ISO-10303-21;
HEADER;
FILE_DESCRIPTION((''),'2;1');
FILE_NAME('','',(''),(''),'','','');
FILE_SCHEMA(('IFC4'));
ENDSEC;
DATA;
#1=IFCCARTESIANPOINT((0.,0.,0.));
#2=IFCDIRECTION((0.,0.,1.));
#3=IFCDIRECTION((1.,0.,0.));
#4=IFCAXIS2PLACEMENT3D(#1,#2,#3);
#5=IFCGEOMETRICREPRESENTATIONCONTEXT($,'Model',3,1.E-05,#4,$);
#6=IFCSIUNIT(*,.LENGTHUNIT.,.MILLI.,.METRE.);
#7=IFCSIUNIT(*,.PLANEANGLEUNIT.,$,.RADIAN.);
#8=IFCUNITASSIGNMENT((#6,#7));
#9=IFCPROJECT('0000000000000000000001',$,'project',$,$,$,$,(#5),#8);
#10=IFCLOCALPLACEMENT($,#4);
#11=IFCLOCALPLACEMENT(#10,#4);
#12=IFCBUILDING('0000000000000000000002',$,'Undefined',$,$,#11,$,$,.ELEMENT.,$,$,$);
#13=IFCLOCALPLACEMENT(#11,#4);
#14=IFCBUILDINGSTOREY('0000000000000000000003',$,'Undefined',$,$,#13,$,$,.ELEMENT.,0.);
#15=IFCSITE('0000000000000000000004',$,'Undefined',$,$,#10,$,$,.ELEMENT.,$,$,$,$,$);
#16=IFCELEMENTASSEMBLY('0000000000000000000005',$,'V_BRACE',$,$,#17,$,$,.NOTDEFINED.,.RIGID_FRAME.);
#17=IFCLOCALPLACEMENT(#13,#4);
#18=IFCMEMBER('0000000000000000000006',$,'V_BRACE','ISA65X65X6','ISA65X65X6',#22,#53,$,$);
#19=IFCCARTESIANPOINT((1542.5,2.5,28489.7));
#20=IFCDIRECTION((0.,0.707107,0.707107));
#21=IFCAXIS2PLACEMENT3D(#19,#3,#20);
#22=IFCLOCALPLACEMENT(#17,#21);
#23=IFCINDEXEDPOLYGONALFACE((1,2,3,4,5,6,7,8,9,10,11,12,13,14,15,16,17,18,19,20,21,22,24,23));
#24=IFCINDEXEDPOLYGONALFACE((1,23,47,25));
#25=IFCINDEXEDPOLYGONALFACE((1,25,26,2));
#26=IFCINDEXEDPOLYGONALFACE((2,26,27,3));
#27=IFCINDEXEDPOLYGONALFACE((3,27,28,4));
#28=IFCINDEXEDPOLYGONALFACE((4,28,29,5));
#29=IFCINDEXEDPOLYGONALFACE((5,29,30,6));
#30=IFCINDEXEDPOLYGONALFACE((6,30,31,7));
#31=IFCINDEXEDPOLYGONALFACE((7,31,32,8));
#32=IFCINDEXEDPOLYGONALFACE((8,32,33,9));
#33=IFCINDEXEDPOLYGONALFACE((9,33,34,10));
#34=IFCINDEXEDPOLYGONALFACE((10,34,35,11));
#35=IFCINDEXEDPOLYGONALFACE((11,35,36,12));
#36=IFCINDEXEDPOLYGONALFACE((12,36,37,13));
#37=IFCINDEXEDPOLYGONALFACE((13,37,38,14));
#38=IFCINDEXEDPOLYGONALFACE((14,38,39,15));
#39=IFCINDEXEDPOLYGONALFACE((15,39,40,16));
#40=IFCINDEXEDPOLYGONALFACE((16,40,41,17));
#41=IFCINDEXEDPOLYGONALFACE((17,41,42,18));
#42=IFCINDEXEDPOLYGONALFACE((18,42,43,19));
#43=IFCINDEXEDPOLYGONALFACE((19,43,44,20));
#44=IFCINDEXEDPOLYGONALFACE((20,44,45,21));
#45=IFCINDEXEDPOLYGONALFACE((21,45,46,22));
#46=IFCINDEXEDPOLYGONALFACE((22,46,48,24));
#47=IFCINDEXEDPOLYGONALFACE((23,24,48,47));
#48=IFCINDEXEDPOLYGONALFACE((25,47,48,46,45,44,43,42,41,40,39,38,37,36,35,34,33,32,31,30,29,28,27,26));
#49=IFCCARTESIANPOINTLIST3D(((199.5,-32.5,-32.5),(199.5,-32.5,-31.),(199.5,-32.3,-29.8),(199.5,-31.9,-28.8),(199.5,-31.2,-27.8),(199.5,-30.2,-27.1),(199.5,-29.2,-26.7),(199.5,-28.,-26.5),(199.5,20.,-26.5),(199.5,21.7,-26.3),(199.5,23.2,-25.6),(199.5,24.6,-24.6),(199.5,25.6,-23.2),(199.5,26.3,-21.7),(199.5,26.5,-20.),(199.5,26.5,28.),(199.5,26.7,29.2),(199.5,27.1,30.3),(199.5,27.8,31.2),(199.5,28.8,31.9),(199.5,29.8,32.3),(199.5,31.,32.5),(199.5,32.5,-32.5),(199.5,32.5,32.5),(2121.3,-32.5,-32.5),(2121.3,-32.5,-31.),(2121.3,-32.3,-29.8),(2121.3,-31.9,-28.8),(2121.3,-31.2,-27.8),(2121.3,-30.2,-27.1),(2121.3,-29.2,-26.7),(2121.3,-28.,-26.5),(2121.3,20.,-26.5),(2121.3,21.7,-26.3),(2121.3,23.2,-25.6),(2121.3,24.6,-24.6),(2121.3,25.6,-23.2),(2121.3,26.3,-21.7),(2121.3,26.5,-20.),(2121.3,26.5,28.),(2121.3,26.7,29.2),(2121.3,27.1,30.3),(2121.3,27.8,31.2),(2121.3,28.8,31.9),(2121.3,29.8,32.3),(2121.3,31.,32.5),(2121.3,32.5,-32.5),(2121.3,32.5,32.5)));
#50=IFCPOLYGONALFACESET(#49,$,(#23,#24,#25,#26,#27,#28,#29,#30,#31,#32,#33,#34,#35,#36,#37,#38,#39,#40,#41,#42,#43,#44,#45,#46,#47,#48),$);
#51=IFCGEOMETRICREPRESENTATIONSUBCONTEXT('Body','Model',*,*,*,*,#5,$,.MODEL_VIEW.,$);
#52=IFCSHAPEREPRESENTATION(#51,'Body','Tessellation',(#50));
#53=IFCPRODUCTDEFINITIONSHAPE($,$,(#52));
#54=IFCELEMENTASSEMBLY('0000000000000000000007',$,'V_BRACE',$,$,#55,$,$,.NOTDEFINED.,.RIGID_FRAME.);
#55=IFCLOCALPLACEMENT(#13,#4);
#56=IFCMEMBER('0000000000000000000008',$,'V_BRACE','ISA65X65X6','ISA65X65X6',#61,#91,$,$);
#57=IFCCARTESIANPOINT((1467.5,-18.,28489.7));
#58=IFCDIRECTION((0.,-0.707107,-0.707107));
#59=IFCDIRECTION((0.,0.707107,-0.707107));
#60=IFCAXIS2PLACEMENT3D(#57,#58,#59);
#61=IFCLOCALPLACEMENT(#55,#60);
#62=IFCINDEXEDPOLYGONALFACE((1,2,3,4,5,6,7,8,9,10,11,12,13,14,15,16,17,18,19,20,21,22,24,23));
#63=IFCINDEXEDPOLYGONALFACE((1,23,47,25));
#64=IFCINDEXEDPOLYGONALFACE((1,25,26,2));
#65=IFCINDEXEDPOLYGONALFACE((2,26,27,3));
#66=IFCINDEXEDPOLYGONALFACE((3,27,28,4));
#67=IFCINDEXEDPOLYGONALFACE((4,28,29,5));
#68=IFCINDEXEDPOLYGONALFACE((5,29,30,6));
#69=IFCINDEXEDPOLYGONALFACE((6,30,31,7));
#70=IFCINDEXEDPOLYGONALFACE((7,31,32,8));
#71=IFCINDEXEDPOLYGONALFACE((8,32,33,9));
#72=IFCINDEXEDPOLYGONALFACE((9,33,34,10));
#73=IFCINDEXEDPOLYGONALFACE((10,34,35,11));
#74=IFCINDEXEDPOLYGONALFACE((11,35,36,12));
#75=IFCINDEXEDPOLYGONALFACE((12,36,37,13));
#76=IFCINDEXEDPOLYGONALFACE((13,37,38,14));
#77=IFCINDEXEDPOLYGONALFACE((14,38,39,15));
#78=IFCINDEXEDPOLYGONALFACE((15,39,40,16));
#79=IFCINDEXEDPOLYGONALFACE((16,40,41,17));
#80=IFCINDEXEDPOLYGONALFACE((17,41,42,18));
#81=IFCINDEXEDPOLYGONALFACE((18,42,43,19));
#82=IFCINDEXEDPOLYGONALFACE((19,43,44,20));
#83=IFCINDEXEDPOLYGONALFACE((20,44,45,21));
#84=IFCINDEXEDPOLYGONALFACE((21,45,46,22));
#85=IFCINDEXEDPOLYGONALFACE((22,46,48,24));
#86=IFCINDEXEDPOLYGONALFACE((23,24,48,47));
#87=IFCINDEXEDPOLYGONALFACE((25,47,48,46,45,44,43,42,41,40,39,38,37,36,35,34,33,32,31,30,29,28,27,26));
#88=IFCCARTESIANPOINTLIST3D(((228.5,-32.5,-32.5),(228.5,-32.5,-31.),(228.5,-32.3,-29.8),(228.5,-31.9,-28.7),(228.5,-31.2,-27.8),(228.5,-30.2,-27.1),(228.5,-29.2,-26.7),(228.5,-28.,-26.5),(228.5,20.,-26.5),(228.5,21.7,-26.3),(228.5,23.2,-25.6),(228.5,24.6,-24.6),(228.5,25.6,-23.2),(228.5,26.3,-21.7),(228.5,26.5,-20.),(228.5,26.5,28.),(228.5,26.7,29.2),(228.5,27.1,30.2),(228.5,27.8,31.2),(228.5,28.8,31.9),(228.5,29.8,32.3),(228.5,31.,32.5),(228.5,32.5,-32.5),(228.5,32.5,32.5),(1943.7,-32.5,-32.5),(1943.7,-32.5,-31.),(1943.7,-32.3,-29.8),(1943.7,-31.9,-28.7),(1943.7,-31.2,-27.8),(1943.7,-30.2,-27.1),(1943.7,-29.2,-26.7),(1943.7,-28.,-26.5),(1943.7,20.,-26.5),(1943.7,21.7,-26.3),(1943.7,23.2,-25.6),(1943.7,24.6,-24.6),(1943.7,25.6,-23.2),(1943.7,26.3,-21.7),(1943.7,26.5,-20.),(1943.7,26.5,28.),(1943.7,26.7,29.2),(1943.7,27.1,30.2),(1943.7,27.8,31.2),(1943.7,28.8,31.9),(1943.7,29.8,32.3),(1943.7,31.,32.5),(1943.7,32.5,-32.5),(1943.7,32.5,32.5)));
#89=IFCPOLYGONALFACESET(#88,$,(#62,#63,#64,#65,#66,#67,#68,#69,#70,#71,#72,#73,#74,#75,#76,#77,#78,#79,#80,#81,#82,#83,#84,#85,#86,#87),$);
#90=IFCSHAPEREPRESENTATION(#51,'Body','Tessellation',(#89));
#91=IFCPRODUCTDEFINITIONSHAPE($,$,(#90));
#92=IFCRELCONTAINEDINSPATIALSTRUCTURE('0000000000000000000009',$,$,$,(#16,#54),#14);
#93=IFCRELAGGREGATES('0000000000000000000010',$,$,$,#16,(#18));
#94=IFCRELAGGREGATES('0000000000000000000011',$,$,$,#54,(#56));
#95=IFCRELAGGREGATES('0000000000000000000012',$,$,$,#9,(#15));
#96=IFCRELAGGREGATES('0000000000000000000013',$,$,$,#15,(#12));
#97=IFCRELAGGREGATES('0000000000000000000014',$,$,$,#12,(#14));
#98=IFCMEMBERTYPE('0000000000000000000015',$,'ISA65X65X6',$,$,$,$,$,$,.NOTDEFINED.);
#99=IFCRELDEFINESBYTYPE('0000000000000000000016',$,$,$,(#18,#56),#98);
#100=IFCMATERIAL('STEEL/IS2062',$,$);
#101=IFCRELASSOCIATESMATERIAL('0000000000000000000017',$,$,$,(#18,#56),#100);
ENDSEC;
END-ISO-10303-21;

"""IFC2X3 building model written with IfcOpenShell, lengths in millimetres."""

from ifc_helpers import new_model, si_unit, frame, origin_with_axes, origin_2d_with_axis, place, context, subcontext, project, spatial, l_section, extrude, clip, halfspace, material, type_object, element, aggregate, save


model = new_model("IFC2X3")

# Units and contexts
model_context = context("Model", 3, precision=1e-05, world=origin_with_axes())
body_context = subcontext(model_context, "Body", "Model", "MODEL_VIEW")
ifc_project = project(units=[si_unit("LENGTHUNIT", "METRE", prefix="MILLI"), si_unit("PLANEANGLEUNIT", "RADIAN")], contexts=[model_context])

# Site, building, storey
site_placement = place(None, origin_with_axes())
site = spatial("IfcSite", under=ifc_project, at=site_placement, Name="Undefined", CompositionType="ELEMENT")
building_placement = place(site_placement, origin_with_axes())
building = spatial("IfcBuilding", under=site, at=building_placement, Name="Undefined", CompositionType="ELEMENT")
storey_placement = place(building_placement, origin_with_axes())
storey = spatial("IfcBuildingStorey", under=building, at=storey_placement, Name="Undefined", CompositionType="ELEMENT", Elevation=0.0)

# Shared definitions
ifc_material_1 = material(Name="STEEL/IS2062")

# Element assemblies, members
assembly_1_placement = place(storey_placement, origin_with_axes())
assembly_1 = element("IfcElementAssembly", 1, at=assembly_1_placement, inside=storey, Name="V_BRACE", AssemblyPlace="NOTDEFINED", PredefinedType="RIGID_FRAME")
member_type = type_object("IfcMemberType", Name="ISA65X65X6", PredefinedType="NOTDEFINED")
member_1_placement = place(assembly_1_placement, frame((1542.5, 2.5, 28489.7), z_axis=(1.0, 0.0, 0.0), x_axis=(0.0, 0.707107, 0.707107)))
member_1 = element("IfcMember", 2, at=member_1_placement, type_object=member_type, material=ifc_material_1, Name="V_BRACE", Description="ISA65X65X6", ObjectType="ISA65X65X6", context=body_context, shape_type="Clipping", body=[
    clip(extrude(l_section(Depth=65.0, Width=65.0, Thickness=6.0, FilletRadius=6.5, EdgeRadius=4.5, at=origin_2d_with_axis()), frame((2121.3, 0.0, 0.0), z_axis=(-1.0, 0.0, 0.0), x_axis=(0.0, -1.0, 0.0)), (0.0, 0.0, 1.0), 2121.3), halfspace(frame((199.5, 0.0, -42.5), z_axis=(1.0, 0.0, 0.0), x_axis=(0.0, -1.0, 0.0)), True)),
])
aggregate(assembly_1, [member_1])
assembly_2_placement = place(storey_placement, origin_with_axes())
assembly_2 = element("IfcElementAssembly", 3, at=assembly_2_placement, inside=storey, Name="V_BRACE", AssemblyPlace="NOTDEFINED", PredefinedType="RIGID_FRAME")
member_2_placement = place(assembly_2_placement, frame((1467.5, -18.0, 28489.7), z_axis=(0.0, -0.707107, -0.707107), x_axis=(0.0, 0.707107, -0.707107)))
member_2 = element("IfcMember", 4, at=member_2_placement, type_object=member_type, material=ifc_material_1, Name="V_BRACE", Description="ISA65X65X6", ObjectType="ISA65X65X6", context=body_context, shape_type="Clipping", body=[
    clip(clip(extrude(l_section(Depth=65.0, Width=65.0, Thickness=6.0, FilletRadius=6.5, EdgeRadius=4.5, at=origin_2d_with_axis()), frame((2121.3, 0.0, 0.0), z_axis=(-1.0, 0.0, 0.0), x_axis=(0.0, -1.0, 0.0)), (0.0, 0.0, 1.0), 2121.3), halfspace(frame((1943.7, 32.5, 0.0), z_axis=(-1.0, 0.0, 0.0), x_axis=(0.0, 0.0, -1.0)), True)), halfspace(frame((228.5, 32.5, 0.0), z_axis=(1.0, 0.0, 0.0), x_axis=(0.0, 0.0, 1.0)), True)),
])
aggregate(assembly_2, [member_2])

save(model, "model.ifc")
